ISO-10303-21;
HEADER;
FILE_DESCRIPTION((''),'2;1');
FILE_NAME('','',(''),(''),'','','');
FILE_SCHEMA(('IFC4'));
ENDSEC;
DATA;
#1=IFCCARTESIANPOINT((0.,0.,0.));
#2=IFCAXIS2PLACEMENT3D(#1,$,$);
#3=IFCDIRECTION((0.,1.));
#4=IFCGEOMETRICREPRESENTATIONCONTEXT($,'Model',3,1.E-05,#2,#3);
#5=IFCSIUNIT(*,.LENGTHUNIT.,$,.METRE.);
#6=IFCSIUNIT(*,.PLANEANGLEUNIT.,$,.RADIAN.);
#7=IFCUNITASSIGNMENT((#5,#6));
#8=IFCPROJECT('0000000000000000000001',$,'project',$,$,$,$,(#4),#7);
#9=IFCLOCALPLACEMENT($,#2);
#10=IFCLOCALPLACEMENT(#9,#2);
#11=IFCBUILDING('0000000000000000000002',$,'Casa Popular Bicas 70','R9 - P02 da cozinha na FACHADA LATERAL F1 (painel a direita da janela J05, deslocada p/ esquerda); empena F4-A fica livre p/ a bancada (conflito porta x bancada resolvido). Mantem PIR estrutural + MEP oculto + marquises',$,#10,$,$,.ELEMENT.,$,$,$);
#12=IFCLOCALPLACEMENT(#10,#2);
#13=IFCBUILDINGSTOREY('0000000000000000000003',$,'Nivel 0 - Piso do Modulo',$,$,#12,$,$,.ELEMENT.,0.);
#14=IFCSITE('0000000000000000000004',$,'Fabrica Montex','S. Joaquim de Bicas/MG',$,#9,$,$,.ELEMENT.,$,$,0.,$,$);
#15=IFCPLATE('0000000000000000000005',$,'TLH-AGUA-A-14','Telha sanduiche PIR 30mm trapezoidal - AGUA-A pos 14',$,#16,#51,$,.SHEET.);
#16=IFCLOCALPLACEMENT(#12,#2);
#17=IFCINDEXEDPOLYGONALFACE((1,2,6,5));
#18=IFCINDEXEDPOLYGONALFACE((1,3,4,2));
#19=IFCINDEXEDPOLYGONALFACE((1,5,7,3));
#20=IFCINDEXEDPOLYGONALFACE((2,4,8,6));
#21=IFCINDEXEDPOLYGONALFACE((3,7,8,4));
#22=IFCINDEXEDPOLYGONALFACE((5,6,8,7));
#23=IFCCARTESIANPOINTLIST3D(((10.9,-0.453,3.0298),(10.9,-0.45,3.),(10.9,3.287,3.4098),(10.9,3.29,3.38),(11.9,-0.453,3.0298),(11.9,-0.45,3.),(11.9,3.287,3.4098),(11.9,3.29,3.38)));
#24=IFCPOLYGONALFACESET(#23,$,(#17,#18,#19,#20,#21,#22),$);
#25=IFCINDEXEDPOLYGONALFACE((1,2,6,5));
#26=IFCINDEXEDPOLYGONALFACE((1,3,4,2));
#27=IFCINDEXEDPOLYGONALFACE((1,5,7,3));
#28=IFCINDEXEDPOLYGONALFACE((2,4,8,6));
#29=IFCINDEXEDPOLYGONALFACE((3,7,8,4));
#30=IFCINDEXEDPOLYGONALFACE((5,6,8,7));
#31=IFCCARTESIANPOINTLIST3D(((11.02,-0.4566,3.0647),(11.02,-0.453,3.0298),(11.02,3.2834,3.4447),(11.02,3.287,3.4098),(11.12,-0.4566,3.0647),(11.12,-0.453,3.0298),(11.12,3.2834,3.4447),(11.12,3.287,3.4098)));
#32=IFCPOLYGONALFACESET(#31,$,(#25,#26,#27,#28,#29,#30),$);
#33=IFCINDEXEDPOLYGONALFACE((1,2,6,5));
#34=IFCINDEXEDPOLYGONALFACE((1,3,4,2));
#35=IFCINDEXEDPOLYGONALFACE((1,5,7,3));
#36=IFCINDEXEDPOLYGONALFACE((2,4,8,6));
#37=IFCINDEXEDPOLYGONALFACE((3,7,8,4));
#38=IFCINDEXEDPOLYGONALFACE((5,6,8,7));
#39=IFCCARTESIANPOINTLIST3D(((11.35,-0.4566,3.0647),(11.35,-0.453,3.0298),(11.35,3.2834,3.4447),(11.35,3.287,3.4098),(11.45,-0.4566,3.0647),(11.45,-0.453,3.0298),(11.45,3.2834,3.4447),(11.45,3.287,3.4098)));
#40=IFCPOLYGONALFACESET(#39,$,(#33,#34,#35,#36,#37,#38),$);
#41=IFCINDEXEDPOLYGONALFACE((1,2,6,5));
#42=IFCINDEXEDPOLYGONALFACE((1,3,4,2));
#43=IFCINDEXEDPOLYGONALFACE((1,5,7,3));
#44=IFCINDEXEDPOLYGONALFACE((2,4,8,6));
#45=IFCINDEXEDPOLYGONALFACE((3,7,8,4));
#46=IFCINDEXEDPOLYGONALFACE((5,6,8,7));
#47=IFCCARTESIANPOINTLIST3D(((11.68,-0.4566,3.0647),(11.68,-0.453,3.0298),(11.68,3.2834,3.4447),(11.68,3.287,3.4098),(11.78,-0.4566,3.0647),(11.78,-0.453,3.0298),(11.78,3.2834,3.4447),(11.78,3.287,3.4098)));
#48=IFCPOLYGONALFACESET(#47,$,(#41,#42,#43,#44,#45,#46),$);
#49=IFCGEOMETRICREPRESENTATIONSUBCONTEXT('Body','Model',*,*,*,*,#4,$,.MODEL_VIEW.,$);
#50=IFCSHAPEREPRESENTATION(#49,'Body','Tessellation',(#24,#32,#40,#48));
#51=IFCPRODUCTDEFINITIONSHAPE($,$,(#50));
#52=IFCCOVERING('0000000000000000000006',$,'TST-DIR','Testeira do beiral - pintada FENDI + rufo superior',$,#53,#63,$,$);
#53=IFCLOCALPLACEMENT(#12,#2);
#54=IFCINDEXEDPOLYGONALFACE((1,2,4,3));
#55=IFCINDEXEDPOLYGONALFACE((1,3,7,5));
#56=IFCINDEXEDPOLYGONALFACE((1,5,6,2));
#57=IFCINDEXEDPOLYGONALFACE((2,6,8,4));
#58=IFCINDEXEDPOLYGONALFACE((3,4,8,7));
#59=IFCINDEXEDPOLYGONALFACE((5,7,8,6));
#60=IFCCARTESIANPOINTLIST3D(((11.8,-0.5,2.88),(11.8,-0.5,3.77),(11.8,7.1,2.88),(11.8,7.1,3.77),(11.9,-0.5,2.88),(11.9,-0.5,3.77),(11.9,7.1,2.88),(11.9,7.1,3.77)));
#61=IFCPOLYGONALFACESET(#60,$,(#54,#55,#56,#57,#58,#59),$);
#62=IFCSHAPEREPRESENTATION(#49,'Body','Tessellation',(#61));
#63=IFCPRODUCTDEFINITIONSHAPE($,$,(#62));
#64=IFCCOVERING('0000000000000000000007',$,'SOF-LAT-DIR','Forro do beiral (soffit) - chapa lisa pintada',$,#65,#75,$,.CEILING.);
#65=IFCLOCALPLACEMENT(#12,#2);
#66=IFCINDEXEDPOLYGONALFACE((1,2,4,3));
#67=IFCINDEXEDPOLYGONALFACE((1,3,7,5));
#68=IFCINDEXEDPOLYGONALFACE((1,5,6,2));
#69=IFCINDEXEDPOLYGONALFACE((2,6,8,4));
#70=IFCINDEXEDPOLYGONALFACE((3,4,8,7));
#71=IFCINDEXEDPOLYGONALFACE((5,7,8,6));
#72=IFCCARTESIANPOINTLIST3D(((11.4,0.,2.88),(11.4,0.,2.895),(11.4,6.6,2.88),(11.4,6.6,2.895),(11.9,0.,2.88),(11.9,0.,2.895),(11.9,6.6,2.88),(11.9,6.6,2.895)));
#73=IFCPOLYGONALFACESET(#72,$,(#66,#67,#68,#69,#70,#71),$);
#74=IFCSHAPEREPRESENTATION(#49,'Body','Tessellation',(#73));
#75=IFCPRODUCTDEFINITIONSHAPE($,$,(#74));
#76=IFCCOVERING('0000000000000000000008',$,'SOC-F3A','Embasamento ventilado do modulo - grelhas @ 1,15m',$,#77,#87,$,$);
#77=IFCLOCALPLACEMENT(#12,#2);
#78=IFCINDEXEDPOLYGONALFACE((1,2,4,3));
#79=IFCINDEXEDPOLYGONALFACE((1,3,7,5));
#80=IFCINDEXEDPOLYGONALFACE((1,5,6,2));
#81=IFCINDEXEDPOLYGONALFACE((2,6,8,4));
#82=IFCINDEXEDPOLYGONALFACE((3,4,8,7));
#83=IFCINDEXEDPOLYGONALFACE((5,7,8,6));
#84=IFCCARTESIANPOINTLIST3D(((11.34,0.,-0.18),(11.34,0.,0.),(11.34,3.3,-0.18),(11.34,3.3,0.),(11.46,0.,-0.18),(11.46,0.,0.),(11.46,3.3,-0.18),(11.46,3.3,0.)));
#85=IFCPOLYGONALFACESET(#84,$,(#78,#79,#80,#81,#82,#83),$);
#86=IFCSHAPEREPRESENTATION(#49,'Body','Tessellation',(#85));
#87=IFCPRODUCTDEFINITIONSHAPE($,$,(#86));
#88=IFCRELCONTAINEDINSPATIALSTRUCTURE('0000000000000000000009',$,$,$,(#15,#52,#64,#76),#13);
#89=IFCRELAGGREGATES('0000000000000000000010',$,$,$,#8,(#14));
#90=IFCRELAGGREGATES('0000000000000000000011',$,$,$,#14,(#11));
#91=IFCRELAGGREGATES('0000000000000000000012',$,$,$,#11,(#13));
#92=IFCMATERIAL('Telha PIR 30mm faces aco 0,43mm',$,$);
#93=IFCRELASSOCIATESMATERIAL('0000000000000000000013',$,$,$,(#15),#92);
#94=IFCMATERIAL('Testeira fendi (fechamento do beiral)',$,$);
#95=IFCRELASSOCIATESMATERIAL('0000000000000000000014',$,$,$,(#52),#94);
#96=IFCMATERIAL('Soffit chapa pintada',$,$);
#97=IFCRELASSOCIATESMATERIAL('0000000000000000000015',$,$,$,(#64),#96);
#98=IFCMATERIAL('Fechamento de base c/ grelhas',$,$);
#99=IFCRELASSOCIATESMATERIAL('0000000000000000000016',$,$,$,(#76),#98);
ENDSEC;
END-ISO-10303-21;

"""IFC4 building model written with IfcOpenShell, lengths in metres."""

from ifc_helpers import new_model, si_unit, direction, frame, frame_2d, origin, place, context, subcontext, project, spatial, rectangle, extrude, material, element, save


model = new_model("IFC4")

# Units and contexts
model_context = context("Model", 3, precision=1e-05, world=origin(), true_north=direction((0.0, 1.0)))
body_context = subcontext(model_context, "Body", "Model", "MODEL_VIEW")
ifc_project = project(units=[si_unit("LENGTHUNIT", "METRE"), si_unit("PLANEANGLEUNIT", "RADIAN")], contexts=[model_context])

# Site, building, storey
site_placement = place(None, origin())
site = spatial("IfcSite", under=ifc_project, at=site_placement, Name="Fabrica Montex", Description="S. Joaquim de Bicas/MG", CompositionType="ELEMENT", RefElevation=0.0)
building_placement = place(site_placement, origin())
building = spatial("IfcBuilding", under=site, at=building_placement, Name="Casa Popular Bicas 70", Description="R9 - P02 da cozinha na FACHADA LATERAL F1 (painel a direita da janela J05, deslocada p/ esquerda); empena F4-A fica livre p/ a bancada (conflito porta x bancada resolvido). Mantem PIR estrutural + MEP oculto + marquises", CompositionType="ELEMENT")
storey_placement = place(building_placement, origin())
storey = spatial("IfcBuildingStorey", under=building, at=storey_placement, Name="Nivel 0 - Piso do Modulo", CompositionType="ELEMENT", Elevation=0.0)

# Plate
ifc_material_1 = material(Name="Telha PIR 30mm faces aco 0,43mm")
for number, where, z_axis, x_axis, name in (
    (1, (10.9, -0.45, 3.0), (0.0, -0.101084, 0.994878), (1.0, 0.0, 0.0), "TLH-AGUA-A-14"),
):
    element("IfcPlate", number, at=place(storey_placement, frame(where, z_axis=z_axis, x_axis=x_axis)), inside=storey, material=ifc_material_1, Name=name, Description="Telha sanduiche PIR 30mm trapezoidal - AGUA-A pos 14", PredefinedType="SHEET", context=body_context, shape_type="SweptSolid", body=[
        extrude(rectangle(XDim=1.0, YDim=3.7593, at=frame_2d((0.5, 1.8796))), origin(), (0.0, 0.0, 1.0), 0.03),
        extrude(rectangle(XDim=0.1, YDim=3.7593, at=frame_2d((0.17, 1.8796))), frame((0.0, 0.0, 0.03)), (0.0, 0.0, 1.0), 0.035),
        extrude(rectangle(XDim=0.1, YDim=3.7593, at=frame_2d((0.5, 1.8796))), frame((0.0, 0.0, 0.03)), (0.0, 0.0, 1.0), 0.035),
        extrude(rectangle(XDim=0.1, YDim=3.7593, at=frame_2d((0.83, 1.8796))), frame((0.0, 0.0, 0.03)), (0.0, 0.0, 1.0), 0.035),
    ])

# Coverings
ifc_material_2 = material(Name="Testeira fendi (fechamento do beiral)")
covering_1_placement = place(storey_placement, frame((11.85, -0.5, 2.88), x_axis=(0.0, 1.0, 0.0)))
element("IfcCovering", 2, at=covering_1_placement, inside=storey, material=ifc_material_2, Name="TST-DIR", Description="Testeira do beiral - pintada FENDI + rufo superior", context=body_context, shape_type="SweptSolid", body=[
    extrude(rectangle(XDim=7.6, YDim=0.1, at=frame_2d((3.8, 0.0))), origin(), (0.0, 0.0, 1.0), 0.89),
])
ifc_material_3 = material(Name="Soffit chapa pintada")
covering_2_placement = place(storey_placement, frame((11.4, 0.0, 2.88)))
element("IfcCovering", 3, at=covering_2_placement, inside=storey, material=ifc_material_3, Name="SOF-LAT-DIR", Description="Forro do beiral (soffit) - chapa lisa pintada", PredefinedType="CEILING", context=body_context, shape_type="SweptSolid", body=[
    extrude(rectangle(XDim=0.5, YDim=6.6, at=frame_2d((0.25, 3.3))), origin(), (0.0, 0.0, 1.0), 0.015),
])
ifc_material_4 = material(Name="Fechamento de base c/ grelhas")
covering_3_placement = place(storey_placement, frame((11.4, 0.0, -0.18), x_axis=(0.0, 1.0, 0.0)))
element("IfcCovering", 4, at=covering_3_placement, inside=storey, material=ifc_material_4, Name="SOC-F3A", Description="Embasamento ventilado do modulo - grelhas @ 1,15m", context=body_context, shape_type="SweptSolid", body=[
    extrude(rectangle(XDim=3.3, YDim=0.12, at=frame_2d((1.65, 0.0))), origin(), (0.0, 0.0, 1.0), 0.18),
])

save(model, "model.ifc")
